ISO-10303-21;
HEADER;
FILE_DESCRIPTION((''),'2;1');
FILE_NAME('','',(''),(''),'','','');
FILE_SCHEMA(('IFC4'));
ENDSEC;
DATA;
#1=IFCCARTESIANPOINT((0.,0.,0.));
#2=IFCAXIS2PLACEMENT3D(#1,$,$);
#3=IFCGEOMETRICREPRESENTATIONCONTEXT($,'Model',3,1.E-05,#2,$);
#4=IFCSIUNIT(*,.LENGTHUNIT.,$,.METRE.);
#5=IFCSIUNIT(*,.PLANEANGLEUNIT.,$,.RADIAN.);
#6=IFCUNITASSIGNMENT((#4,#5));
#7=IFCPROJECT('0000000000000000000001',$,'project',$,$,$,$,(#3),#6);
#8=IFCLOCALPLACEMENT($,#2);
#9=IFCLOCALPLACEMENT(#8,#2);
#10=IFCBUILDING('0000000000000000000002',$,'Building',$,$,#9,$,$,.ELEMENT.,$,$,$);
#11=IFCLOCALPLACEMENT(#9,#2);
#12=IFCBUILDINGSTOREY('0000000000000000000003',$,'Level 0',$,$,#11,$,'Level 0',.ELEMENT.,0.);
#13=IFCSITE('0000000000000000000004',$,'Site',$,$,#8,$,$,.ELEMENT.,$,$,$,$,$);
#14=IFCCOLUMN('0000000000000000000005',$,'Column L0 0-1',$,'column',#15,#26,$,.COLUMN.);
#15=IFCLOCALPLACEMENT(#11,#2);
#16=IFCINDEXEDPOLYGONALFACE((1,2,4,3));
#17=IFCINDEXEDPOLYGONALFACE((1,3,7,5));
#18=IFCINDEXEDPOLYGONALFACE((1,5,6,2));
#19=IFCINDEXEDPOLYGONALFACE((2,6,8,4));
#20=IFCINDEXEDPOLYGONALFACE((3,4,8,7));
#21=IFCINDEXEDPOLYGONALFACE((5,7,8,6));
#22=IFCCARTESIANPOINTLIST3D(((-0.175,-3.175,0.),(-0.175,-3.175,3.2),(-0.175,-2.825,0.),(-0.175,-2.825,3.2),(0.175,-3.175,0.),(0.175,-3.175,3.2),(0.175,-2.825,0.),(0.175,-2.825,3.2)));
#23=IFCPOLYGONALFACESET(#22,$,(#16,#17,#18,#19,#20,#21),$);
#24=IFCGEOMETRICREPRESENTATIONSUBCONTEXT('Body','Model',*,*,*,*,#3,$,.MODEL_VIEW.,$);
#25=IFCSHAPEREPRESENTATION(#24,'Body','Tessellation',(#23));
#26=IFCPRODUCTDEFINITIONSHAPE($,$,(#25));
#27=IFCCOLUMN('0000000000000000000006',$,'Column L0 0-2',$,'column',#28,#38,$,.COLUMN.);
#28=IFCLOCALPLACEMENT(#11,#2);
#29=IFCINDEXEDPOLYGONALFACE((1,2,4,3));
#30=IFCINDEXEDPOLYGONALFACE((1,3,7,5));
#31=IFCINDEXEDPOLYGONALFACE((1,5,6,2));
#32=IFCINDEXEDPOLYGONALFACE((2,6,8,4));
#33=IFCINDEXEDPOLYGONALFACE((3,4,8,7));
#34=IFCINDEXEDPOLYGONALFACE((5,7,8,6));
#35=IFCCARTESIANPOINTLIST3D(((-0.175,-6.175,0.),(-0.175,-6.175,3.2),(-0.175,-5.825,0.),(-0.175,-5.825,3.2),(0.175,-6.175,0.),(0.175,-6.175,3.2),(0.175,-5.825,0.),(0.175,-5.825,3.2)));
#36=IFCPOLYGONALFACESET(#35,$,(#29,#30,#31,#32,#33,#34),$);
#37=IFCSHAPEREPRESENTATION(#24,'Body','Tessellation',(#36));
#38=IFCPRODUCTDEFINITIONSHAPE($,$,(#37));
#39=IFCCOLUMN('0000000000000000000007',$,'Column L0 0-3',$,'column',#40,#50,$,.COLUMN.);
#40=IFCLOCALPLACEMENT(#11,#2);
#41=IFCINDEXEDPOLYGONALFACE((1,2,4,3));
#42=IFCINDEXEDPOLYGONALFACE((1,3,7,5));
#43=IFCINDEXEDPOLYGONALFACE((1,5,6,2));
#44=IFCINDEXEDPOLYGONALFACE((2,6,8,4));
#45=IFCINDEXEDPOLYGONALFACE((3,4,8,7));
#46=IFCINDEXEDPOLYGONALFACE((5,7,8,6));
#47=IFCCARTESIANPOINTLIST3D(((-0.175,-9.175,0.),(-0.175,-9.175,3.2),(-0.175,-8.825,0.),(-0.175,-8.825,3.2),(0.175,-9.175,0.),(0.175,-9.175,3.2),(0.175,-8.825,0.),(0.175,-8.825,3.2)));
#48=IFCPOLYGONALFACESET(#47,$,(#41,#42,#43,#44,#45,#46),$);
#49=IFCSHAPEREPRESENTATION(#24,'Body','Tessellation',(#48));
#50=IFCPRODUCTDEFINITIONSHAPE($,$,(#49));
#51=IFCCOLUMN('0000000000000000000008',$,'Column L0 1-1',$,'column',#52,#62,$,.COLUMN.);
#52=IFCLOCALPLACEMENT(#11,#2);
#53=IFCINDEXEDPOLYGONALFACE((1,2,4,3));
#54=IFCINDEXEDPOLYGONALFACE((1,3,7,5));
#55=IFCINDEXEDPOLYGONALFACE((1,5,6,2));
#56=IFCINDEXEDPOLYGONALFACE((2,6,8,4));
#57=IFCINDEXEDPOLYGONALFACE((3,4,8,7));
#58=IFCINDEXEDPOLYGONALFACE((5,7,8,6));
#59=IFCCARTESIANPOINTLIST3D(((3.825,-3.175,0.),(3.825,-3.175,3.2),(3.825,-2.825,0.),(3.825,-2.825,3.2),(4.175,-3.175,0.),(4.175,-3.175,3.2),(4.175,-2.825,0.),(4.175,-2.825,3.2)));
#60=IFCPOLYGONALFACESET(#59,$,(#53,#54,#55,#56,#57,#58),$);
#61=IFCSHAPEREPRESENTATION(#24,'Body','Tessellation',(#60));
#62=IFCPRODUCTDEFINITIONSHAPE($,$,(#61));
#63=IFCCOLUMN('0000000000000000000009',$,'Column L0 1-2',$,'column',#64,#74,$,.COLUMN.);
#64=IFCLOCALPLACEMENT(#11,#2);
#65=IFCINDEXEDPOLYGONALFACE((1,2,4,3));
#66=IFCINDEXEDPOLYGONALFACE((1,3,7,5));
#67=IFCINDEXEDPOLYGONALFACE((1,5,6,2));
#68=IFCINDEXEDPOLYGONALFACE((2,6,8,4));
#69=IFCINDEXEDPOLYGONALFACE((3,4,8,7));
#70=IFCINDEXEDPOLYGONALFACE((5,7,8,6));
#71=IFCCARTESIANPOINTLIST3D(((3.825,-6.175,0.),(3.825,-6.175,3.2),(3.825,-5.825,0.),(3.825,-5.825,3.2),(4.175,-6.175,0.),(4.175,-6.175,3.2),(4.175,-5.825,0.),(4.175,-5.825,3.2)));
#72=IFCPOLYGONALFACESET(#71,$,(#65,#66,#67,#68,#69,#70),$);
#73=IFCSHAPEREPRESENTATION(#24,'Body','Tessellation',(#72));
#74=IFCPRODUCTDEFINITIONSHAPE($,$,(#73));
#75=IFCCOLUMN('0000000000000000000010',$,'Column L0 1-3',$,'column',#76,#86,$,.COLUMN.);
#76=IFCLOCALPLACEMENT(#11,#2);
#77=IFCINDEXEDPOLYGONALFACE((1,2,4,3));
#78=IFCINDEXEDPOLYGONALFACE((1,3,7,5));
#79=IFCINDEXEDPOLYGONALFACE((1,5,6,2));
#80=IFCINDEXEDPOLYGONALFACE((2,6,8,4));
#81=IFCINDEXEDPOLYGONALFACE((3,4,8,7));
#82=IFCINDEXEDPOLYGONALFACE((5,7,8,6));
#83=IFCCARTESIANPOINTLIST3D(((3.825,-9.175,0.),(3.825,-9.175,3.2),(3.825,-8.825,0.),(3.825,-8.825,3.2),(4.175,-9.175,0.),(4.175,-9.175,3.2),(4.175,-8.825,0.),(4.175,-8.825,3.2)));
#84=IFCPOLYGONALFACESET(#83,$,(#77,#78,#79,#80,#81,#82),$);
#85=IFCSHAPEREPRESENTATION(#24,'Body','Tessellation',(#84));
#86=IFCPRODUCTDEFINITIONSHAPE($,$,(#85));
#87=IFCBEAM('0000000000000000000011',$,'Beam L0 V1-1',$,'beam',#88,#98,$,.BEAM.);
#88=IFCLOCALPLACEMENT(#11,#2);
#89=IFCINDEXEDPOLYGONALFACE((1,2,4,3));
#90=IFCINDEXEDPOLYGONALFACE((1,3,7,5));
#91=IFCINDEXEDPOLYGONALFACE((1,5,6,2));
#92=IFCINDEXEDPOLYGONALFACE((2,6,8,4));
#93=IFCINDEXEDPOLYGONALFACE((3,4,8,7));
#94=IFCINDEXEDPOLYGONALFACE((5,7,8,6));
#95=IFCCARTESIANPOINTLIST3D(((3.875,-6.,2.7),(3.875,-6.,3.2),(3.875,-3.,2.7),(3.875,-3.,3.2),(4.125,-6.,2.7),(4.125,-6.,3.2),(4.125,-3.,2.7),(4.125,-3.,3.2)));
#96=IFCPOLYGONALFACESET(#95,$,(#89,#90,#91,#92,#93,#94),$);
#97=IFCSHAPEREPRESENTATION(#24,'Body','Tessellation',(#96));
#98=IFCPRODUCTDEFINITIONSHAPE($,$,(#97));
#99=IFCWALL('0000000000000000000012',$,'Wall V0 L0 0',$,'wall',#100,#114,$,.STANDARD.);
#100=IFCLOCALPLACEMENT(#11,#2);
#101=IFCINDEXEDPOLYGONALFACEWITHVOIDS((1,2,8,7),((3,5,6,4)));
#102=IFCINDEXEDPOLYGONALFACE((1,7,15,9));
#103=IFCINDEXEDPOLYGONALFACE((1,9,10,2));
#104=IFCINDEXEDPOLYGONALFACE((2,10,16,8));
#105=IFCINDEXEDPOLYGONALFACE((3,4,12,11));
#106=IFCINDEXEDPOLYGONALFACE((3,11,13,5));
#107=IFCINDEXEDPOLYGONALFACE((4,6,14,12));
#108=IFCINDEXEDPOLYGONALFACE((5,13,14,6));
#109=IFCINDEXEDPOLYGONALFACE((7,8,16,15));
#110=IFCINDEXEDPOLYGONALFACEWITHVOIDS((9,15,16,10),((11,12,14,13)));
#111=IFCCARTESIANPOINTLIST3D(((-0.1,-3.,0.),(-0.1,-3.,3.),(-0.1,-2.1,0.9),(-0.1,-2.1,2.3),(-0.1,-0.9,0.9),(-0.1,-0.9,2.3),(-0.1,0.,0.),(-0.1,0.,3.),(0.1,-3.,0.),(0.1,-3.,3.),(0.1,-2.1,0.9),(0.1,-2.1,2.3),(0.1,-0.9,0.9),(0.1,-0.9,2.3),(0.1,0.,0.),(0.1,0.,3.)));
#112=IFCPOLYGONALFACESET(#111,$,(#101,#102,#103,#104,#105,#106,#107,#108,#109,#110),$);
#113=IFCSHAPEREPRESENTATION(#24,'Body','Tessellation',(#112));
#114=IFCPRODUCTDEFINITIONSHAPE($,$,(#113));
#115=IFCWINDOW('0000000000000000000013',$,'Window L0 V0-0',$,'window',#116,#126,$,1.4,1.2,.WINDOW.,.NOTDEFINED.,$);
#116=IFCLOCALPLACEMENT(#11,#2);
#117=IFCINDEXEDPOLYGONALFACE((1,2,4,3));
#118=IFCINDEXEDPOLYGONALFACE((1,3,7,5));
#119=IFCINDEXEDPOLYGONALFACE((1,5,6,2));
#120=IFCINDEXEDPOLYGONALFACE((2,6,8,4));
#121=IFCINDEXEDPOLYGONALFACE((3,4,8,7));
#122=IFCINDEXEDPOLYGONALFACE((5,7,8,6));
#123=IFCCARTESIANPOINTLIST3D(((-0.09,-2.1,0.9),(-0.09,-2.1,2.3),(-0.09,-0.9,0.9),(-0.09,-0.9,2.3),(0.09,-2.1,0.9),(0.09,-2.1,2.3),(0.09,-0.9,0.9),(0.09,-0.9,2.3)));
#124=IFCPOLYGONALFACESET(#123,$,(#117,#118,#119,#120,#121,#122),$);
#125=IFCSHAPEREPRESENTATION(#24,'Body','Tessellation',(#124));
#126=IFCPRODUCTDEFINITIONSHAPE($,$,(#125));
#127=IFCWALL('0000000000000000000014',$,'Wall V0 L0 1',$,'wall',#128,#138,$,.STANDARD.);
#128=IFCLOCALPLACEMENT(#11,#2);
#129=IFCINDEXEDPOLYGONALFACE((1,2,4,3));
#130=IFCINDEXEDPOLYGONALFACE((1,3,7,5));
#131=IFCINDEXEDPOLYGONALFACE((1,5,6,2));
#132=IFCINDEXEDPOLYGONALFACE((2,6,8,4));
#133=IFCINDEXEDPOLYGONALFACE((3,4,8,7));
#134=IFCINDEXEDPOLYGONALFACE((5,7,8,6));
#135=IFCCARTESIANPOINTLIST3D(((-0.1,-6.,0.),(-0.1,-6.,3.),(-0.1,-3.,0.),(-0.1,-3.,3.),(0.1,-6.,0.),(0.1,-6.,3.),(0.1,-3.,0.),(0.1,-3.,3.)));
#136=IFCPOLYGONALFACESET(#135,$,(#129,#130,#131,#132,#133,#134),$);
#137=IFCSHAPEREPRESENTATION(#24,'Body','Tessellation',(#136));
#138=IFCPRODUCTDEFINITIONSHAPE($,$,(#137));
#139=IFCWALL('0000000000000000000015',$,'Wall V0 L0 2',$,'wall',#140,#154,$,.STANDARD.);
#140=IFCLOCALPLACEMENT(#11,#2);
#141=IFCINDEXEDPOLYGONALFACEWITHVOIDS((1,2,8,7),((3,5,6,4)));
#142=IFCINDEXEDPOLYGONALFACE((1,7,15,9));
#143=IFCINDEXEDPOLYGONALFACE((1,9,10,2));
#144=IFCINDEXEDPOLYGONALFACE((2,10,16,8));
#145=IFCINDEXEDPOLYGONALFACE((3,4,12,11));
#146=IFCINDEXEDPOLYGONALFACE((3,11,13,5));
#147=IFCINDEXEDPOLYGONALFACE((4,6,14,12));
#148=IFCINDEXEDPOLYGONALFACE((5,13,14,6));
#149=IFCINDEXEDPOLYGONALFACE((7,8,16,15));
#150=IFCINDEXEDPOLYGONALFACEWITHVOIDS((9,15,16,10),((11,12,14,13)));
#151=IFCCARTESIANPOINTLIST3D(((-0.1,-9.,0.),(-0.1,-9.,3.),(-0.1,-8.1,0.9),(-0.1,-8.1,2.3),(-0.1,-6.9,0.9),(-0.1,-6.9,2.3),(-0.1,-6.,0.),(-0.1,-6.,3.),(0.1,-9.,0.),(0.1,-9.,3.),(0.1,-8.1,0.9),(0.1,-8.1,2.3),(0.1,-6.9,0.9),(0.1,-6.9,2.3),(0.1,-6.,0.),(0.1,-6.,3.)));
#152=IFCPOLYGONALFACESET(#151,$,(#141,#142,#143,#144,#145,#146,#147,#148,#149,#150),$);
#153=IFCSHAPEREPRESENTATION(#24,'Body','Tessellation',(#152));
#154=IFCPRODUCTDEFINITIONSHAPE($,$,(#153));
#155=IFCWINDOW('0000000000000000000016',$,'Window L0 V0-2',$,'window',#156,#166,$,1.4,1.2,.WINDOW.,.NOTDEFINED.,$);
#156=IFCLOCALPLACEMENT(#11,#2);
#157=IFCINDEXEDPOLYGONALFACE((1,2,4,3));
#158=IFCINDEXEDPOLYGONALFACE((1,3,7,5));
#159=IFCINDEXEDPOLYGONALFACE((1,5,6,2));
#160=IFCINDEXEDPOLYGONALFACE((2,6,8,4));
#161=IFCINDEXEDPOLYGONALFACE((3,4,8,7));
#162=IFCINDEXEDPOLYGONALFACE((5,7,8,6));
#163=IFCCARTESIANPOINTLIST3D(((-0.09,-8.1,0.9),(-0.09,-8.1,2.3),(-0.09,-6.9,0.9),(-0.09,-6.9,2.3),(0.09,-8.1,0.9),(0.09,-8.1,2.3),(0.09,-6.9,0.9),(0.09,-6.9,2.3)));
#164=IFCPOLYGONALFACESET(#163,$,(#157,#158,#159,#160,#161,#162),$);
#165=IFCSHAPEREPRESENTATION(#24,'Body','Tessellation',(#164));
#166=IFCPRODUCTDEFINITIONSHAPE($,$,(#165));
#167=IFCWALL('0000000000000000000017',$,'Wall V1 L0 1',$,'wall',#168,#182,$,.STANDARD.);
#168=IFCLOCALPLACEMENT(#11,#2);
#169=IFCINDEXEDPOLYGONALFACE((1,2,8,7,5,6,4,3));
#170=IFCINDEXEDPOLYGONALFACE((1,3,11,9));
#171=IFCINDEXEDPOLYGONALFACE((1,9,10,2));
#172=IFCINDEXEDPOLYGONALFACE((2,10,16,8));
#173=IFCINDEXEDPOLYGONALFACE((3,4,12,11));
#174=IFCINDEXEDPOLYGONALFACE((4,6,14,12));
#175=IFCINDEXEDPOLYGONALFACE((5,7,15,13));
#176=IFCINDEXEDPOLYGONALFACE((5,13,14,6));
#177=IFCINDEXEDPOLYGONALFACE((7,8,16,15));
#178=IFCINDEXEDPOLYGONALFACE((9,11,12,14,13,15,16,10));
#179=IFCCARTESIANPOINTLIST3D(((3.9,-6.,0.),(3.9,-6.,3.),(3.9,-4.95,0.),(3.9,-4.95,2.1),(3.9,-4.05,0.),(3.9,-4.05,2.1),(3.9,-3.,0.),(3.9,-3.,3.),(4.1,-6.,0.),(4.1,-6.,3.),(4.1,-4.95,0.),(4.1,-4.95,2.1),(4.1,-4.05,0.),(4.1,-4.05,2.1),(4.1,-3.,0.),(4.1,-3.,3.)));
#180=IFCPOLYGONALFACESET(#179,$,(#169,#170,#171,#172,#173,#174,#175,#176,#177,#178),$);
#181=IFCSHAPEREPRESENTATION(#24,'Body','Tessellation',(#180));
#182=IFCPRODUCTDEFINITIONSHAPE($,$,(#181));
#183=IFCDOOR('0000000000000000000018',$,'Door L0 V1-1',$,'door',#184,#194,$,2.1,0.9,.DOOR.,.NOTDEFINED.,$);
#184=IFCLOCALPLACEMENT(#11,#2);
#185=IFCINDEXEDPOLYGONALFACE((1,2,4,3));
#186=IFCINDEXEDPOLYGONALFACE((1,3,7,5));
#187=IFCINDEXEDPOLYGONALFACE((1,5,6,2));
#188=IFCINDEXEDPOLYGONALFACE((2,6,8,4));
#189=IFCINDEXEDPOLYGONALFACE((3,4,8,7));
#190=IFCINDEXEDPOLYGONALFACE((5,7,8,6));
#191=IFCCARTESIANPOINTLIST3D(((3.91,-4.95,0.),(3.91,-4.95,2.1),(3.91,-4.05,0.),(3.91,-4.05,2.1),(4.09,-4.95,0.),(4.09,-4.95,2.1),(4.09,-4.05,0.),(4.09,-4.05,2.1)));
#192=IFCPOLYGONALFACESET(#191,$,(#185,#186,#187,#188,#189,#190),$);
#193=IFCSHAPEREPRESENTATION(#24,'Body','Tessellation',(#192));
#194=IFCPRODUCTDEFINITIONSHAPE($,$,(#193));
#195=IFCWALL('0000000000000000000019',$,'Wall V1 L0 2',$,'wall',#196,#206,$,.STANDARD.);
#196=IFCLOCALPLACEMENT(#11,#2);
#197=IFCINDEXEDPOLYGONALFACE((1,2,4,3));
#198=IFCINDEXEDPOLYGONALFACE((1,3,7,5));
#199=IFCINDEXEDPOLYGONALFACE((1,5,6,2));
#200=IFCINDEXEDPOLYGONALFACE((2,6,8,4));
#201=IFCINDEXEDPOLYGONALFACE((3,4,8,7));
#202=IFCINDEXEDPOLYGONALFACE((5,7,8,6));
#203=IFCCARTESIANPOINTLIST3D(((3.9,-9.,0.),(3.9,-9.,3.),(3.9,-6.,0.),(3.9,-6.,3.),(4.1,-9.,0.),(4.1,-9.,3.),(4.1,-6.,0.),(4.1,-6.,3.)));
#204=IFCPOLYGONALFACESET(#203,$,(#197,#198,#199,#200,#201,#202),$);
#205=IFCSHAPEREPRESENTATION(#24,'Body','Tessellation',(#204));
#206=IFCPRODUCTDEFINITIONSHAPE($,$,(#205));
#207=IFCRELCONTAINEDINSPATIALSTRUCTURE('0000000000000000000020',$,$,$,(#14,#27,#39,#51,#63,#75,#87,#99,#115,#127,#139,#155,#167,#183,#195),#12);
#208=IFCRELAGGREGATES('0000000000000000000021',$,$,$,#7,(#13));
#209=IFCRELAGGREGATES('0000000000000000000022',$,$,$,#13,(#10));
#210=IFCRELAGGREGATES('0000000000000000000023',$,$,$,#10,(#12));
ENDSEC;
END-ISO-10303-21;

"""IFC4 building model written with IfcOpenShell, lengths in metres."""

from ifc_helpers import new_model, si_unit, frame, frame_2d, origin, origin_2d, place, context, subcontext, project, spatial, rectangle, extrude, element, fill, save


model = new_model("IFC4")

# Units and contexts
model_context = context("Model", 3, precision=1e-05, world=origin())
body_context = subcontext(model_context, "Body", "Model", "MODEL_VIEW")
ifc_project = project(units=[si_unit("LENGTHUNIT", "METRE"), si_unit("PLANEANGLEUNIT", "RADIAN")], contexts=[model_context])

# Site, building, storey
site_placement = place(None, origin())
site = spatial("IfcSite", under=ifc_project, at=site_placement, Name="Site", CompositionType="ELEMENT")
building_placement = place(site_placement, origin())
building = spatial("IfcBuilding", under=site, at=building_placement, Name="Building", CompositionType="ELEMENT")
storey_placement = place(building_placement, origin())
storey = spatial("IfcBuildingStorey", under=building, at=storey_placement, Name="Level 0", LongName="Level 0", CompositionType="ELEMENT", Elevation=0.0)

# Columns
for number, where, name in (
    (1, (0.0, -3.0, 0.0), "Column L0 0-1"),
    (2, (0.0, -6.0, 0.0), "Column L0 0-2"),
    (3, (0.0, -9.0, 0.0), "Column L0 0-3"),
    (4, (4.0, -3.0, 0.0), "Column L0 1-1"),
    (5, (4.0, -6.0, 0.0), "Column L0 1-2"),
    (6, (4.0, -9.0, 0.0), "Column L0 1-3"),
):
    element("IfcColumn", number, at=place(storey_placement, frame(where)), inside=storey, Name=name, ObjectType="column", PredefinedType="COLUMN", context=body_context, shape_type="SweptSolid", body=[
        extrude(rectangle(XDim=0.35, YDim=0.35, at=origin_2d()), origin(), (0.0, 0.0, 1.0), 3.2),
    ])

# Beam
beam_placement = place(storey_placement, frame((4.0, -3.0, 2.95), z_axis=(0.0, -1.0, 0.0), x_axis=(0.0, 0.0, 1.0)))
element("IfcBeam", 7, at=beam_placement, inside=storey, Name="Beam L0 V1-1", ObjectType="beam", PredefinedType="BEAM", context=body_context, shape_type="SweptSolid", body=[
    extrude(rectangle(XDim=0.5, YDim=0.25, at=origin_2d()), origin(), (0.0, 0.0, 1.0), 3.0),
])

# Wall, opening, window
wall_1_placement = place(storey_placement, frame((0.0, 0.0, 0.0), z_axis=(0.0, 0.0, 1.0), x_axis=(0.0, -1.0, 0.0)))
wall_1 = element("IfcWall", 8, at=wall_1_placement, inside=storey, Name="Wall V0 L0 0", ObjectType="wall", PredefinedType="STANDARD", context=body_context, shape_type="SweptSolid", body=[
    extrude(rectangle(XDim=3.0, YDim=0.2, at=frame_2d((1.5, 0.0))), origin(), (0.0, 0.0, 1.0), 3.0),
])
opening_1_placement = place(storey_placement, frame((0.0, -1.5, 0.9), z_axis=(0.0, 0.0, 1.0), x_axis=(0.0, -1.0, 0.0)))
opening_1 = element("IfcOpeningElement", 9, at=opening_1_placement, cuts=wall_1, ObjectType="Opening", PredefinedType="OPENING", context=body_context, shape_type="SweptSolid", body=[
    extrude(rectangle(XDim=1.2, YDim=0.22, at=origin_2d()), origin(), (0.0, 0.0, 1.0), 1.4),
])
window_1_placement = place(storey_placement, frame((0.0, -1.5, 0.9), z_axis=(0.0, 0.0, 1.0), x_axis=(0.0, -1.0, 0.0)))
window_1 = element("IfcWindow", 10, at=window_1_placement, inside=storey, Name="Window L0 V0-0", ObjectType="window", OverallHeight=1.4, OverallWidth=1.2, PartitioningType="NOTDEFINED", PredefinedType="WINDOW", context=body_context, shape_type="SweptSolid", body=[
    extrude(rectangle(XDim=1.2, YDim=0.18, at=origin_2d()), origin(), (0.0, 0.0, 1.0), 1.4),
])
fill(opening_1, window_1)

# Wall
wall_2_placement = place(storey_placement, frame((0.0, -3.0, 0.0), z_axis=(0.0, 0.0, 1.0), x_axis=(0.0, -1.0, 0.0)))
element("IfcWall", 11, at=wall_2_placement, inside=storey, Name="Wall V0 L0 1", ObjectType="wall", PredefinedType="STANDARD", context=body_context, shape_type="SweptSolid", body=[
    extrude(rectangle(XDim=3.0, YDim=0.2, at=frame_2d((1.5, 0.0))), origin(), (0.0, 0.0, 1.0), 3.0),
])

# Wall, opening, window
wall_3_placement = place(storey_placement, frame((0.0, -6.0, 0.0), z_axis=(0.0, 0.0, 1.0), x_axis=(0.0, -1.0, 0.0)))
wall_3 = element("IfcWall", 12, at=wall_3_placement, inside=storey, Name="Wall V0 L0 2", ObjectType="wall", PredefinedType="STANDARD", context=body_context, shape_type="SweptSolid", body=[
    extrude(rectangle(XDim=3.0, YDim=0.2, at=frame_2d((1.5, 0.0))), origin(), (0.0, 0.0, 1.0), 3.0),
])
opening_2_placement = place(storey_placement, frame((0.0, -7.5, 0.9), z_axis=(0.0, 0.0, 1.0), x_axis=(0.0, -1.0, 0.0)))
opening_2 = element("IfcOpeningElement", 13, at=opening_2_placement, cuts=wall_3, ObjectType="Opening", PredefinedType="OPENING", context=body_context, shape_type="SweptSolid", body=[
    extrude(rectangle(XDim=1.2, YDim=0.22, at=origin_2d()), origin(), (0.0, 0.0, 1.0), 1.4),
])
window_2_placement = place(storey_placement, frame((0.0, -7.5, 0.9), z_axis=(0.0, 0.0, 1.0), x_axis=(0.0, -1.0, 0.0)))
window_2 = element("IfcWindow", 14, at=window_2_placement, inside=storey, Name="Window L0 V0-2", ObjectType="window", OverallHeight=1.4, OverallWidth=1.2, PartitioningType="NOTDEFINED", PredefinedType="WINDOW", context=body_context, shape_type="SweptSolid", body=[
    extrude(rectangle(XDim=1.2, YDim=0.18, at=origin_2d()), origin(), (0.0, 0.0, 1.0), 1.4),
])
fill(opening_2, window_2)

# Wall, opening, door
wall_4_placement = place(storey_placement, frame((4.0, -3.0, 0.0), z_axis=(0.0, 0.0, 1.0), x_axis=(0.0, -1.0, 0.0)))
wall_4 = element("IfcWall", 15, at=wall_4_placement, inside=storey, Name="Wall V1 L0 1", ObjectType="wall", PredefinedType="STANDARD", context=body_context, shape_type="SweptSolid", body=[
    extrude(rectangle(XDim=3.0, YDim=0.2, at=frame_2d((1.5, 0.0))), origin(), (0.0, 0.0, 1.0), 3.0),
])
opening_3_placement = place(storey_placement, frame((4.0, -4.5, 0.0), z_axis=(0.0, 0.0, 1.0), x_axis=(0.0, -1.0, 0.0)))
opening_3 = element("IfcOpeningElement", 16, at=opening_3_placement, cuts=wall_4, ObjectType="Opening", PredefinedType="OPENING", context=body_context, shape_type="SweptSolid", body=[
    extrude(rectangle(XDim=0.9, YDim=0.22, at=origin_2d()), origin(), (0.0, 0.0, 1.0), 2.1),
])
door_placement = place(storey_placement, frame((4.0, -4.5, 0.0), z_axis=(0.0, 0.0, 1.0), x_axis=(0.0, -1.0, 0.0)))
door = element("IfcDoor", 17, at=door_placement, inside=storey, Name="Door L0 V1-1", ObjectType="door", OperationType="NOTDEFINED", OverallHeight=2.1, OverallWidth=0.9, PredefinedType="DOOR", context=body_context, shape_type="SweptSolid", body=[
    extrude(rectangle(XDim=0.9, YDim=0.18, at=origin_2d()), origin(), (0.0, 0.0, 1.0), 2.1),
])
fill(opening_3, door)

# Wall
wall_5_placement = place(storey_placement, frame((4.0, -6.0, 0.0), z_axis=(0.0, 0.0, 1.0), x_axis=(0.0, -1.0, 0.0)))
element("IfcWall", 18, at=wall_5_placement, inside=storey, Name="Wall V1 L0 2", ObjectType="wall", PredefinedType="STANDARD", context=body_context, shape_type="SweptSolid", body=[
    extrude(rectangle(XDim=3.0, YDim=0.2, at=frame_2d((1.5, 0.0))), origin(), (0.0, 0.0, 1.0), 3.0),
])

save(model, "model.ifc")
